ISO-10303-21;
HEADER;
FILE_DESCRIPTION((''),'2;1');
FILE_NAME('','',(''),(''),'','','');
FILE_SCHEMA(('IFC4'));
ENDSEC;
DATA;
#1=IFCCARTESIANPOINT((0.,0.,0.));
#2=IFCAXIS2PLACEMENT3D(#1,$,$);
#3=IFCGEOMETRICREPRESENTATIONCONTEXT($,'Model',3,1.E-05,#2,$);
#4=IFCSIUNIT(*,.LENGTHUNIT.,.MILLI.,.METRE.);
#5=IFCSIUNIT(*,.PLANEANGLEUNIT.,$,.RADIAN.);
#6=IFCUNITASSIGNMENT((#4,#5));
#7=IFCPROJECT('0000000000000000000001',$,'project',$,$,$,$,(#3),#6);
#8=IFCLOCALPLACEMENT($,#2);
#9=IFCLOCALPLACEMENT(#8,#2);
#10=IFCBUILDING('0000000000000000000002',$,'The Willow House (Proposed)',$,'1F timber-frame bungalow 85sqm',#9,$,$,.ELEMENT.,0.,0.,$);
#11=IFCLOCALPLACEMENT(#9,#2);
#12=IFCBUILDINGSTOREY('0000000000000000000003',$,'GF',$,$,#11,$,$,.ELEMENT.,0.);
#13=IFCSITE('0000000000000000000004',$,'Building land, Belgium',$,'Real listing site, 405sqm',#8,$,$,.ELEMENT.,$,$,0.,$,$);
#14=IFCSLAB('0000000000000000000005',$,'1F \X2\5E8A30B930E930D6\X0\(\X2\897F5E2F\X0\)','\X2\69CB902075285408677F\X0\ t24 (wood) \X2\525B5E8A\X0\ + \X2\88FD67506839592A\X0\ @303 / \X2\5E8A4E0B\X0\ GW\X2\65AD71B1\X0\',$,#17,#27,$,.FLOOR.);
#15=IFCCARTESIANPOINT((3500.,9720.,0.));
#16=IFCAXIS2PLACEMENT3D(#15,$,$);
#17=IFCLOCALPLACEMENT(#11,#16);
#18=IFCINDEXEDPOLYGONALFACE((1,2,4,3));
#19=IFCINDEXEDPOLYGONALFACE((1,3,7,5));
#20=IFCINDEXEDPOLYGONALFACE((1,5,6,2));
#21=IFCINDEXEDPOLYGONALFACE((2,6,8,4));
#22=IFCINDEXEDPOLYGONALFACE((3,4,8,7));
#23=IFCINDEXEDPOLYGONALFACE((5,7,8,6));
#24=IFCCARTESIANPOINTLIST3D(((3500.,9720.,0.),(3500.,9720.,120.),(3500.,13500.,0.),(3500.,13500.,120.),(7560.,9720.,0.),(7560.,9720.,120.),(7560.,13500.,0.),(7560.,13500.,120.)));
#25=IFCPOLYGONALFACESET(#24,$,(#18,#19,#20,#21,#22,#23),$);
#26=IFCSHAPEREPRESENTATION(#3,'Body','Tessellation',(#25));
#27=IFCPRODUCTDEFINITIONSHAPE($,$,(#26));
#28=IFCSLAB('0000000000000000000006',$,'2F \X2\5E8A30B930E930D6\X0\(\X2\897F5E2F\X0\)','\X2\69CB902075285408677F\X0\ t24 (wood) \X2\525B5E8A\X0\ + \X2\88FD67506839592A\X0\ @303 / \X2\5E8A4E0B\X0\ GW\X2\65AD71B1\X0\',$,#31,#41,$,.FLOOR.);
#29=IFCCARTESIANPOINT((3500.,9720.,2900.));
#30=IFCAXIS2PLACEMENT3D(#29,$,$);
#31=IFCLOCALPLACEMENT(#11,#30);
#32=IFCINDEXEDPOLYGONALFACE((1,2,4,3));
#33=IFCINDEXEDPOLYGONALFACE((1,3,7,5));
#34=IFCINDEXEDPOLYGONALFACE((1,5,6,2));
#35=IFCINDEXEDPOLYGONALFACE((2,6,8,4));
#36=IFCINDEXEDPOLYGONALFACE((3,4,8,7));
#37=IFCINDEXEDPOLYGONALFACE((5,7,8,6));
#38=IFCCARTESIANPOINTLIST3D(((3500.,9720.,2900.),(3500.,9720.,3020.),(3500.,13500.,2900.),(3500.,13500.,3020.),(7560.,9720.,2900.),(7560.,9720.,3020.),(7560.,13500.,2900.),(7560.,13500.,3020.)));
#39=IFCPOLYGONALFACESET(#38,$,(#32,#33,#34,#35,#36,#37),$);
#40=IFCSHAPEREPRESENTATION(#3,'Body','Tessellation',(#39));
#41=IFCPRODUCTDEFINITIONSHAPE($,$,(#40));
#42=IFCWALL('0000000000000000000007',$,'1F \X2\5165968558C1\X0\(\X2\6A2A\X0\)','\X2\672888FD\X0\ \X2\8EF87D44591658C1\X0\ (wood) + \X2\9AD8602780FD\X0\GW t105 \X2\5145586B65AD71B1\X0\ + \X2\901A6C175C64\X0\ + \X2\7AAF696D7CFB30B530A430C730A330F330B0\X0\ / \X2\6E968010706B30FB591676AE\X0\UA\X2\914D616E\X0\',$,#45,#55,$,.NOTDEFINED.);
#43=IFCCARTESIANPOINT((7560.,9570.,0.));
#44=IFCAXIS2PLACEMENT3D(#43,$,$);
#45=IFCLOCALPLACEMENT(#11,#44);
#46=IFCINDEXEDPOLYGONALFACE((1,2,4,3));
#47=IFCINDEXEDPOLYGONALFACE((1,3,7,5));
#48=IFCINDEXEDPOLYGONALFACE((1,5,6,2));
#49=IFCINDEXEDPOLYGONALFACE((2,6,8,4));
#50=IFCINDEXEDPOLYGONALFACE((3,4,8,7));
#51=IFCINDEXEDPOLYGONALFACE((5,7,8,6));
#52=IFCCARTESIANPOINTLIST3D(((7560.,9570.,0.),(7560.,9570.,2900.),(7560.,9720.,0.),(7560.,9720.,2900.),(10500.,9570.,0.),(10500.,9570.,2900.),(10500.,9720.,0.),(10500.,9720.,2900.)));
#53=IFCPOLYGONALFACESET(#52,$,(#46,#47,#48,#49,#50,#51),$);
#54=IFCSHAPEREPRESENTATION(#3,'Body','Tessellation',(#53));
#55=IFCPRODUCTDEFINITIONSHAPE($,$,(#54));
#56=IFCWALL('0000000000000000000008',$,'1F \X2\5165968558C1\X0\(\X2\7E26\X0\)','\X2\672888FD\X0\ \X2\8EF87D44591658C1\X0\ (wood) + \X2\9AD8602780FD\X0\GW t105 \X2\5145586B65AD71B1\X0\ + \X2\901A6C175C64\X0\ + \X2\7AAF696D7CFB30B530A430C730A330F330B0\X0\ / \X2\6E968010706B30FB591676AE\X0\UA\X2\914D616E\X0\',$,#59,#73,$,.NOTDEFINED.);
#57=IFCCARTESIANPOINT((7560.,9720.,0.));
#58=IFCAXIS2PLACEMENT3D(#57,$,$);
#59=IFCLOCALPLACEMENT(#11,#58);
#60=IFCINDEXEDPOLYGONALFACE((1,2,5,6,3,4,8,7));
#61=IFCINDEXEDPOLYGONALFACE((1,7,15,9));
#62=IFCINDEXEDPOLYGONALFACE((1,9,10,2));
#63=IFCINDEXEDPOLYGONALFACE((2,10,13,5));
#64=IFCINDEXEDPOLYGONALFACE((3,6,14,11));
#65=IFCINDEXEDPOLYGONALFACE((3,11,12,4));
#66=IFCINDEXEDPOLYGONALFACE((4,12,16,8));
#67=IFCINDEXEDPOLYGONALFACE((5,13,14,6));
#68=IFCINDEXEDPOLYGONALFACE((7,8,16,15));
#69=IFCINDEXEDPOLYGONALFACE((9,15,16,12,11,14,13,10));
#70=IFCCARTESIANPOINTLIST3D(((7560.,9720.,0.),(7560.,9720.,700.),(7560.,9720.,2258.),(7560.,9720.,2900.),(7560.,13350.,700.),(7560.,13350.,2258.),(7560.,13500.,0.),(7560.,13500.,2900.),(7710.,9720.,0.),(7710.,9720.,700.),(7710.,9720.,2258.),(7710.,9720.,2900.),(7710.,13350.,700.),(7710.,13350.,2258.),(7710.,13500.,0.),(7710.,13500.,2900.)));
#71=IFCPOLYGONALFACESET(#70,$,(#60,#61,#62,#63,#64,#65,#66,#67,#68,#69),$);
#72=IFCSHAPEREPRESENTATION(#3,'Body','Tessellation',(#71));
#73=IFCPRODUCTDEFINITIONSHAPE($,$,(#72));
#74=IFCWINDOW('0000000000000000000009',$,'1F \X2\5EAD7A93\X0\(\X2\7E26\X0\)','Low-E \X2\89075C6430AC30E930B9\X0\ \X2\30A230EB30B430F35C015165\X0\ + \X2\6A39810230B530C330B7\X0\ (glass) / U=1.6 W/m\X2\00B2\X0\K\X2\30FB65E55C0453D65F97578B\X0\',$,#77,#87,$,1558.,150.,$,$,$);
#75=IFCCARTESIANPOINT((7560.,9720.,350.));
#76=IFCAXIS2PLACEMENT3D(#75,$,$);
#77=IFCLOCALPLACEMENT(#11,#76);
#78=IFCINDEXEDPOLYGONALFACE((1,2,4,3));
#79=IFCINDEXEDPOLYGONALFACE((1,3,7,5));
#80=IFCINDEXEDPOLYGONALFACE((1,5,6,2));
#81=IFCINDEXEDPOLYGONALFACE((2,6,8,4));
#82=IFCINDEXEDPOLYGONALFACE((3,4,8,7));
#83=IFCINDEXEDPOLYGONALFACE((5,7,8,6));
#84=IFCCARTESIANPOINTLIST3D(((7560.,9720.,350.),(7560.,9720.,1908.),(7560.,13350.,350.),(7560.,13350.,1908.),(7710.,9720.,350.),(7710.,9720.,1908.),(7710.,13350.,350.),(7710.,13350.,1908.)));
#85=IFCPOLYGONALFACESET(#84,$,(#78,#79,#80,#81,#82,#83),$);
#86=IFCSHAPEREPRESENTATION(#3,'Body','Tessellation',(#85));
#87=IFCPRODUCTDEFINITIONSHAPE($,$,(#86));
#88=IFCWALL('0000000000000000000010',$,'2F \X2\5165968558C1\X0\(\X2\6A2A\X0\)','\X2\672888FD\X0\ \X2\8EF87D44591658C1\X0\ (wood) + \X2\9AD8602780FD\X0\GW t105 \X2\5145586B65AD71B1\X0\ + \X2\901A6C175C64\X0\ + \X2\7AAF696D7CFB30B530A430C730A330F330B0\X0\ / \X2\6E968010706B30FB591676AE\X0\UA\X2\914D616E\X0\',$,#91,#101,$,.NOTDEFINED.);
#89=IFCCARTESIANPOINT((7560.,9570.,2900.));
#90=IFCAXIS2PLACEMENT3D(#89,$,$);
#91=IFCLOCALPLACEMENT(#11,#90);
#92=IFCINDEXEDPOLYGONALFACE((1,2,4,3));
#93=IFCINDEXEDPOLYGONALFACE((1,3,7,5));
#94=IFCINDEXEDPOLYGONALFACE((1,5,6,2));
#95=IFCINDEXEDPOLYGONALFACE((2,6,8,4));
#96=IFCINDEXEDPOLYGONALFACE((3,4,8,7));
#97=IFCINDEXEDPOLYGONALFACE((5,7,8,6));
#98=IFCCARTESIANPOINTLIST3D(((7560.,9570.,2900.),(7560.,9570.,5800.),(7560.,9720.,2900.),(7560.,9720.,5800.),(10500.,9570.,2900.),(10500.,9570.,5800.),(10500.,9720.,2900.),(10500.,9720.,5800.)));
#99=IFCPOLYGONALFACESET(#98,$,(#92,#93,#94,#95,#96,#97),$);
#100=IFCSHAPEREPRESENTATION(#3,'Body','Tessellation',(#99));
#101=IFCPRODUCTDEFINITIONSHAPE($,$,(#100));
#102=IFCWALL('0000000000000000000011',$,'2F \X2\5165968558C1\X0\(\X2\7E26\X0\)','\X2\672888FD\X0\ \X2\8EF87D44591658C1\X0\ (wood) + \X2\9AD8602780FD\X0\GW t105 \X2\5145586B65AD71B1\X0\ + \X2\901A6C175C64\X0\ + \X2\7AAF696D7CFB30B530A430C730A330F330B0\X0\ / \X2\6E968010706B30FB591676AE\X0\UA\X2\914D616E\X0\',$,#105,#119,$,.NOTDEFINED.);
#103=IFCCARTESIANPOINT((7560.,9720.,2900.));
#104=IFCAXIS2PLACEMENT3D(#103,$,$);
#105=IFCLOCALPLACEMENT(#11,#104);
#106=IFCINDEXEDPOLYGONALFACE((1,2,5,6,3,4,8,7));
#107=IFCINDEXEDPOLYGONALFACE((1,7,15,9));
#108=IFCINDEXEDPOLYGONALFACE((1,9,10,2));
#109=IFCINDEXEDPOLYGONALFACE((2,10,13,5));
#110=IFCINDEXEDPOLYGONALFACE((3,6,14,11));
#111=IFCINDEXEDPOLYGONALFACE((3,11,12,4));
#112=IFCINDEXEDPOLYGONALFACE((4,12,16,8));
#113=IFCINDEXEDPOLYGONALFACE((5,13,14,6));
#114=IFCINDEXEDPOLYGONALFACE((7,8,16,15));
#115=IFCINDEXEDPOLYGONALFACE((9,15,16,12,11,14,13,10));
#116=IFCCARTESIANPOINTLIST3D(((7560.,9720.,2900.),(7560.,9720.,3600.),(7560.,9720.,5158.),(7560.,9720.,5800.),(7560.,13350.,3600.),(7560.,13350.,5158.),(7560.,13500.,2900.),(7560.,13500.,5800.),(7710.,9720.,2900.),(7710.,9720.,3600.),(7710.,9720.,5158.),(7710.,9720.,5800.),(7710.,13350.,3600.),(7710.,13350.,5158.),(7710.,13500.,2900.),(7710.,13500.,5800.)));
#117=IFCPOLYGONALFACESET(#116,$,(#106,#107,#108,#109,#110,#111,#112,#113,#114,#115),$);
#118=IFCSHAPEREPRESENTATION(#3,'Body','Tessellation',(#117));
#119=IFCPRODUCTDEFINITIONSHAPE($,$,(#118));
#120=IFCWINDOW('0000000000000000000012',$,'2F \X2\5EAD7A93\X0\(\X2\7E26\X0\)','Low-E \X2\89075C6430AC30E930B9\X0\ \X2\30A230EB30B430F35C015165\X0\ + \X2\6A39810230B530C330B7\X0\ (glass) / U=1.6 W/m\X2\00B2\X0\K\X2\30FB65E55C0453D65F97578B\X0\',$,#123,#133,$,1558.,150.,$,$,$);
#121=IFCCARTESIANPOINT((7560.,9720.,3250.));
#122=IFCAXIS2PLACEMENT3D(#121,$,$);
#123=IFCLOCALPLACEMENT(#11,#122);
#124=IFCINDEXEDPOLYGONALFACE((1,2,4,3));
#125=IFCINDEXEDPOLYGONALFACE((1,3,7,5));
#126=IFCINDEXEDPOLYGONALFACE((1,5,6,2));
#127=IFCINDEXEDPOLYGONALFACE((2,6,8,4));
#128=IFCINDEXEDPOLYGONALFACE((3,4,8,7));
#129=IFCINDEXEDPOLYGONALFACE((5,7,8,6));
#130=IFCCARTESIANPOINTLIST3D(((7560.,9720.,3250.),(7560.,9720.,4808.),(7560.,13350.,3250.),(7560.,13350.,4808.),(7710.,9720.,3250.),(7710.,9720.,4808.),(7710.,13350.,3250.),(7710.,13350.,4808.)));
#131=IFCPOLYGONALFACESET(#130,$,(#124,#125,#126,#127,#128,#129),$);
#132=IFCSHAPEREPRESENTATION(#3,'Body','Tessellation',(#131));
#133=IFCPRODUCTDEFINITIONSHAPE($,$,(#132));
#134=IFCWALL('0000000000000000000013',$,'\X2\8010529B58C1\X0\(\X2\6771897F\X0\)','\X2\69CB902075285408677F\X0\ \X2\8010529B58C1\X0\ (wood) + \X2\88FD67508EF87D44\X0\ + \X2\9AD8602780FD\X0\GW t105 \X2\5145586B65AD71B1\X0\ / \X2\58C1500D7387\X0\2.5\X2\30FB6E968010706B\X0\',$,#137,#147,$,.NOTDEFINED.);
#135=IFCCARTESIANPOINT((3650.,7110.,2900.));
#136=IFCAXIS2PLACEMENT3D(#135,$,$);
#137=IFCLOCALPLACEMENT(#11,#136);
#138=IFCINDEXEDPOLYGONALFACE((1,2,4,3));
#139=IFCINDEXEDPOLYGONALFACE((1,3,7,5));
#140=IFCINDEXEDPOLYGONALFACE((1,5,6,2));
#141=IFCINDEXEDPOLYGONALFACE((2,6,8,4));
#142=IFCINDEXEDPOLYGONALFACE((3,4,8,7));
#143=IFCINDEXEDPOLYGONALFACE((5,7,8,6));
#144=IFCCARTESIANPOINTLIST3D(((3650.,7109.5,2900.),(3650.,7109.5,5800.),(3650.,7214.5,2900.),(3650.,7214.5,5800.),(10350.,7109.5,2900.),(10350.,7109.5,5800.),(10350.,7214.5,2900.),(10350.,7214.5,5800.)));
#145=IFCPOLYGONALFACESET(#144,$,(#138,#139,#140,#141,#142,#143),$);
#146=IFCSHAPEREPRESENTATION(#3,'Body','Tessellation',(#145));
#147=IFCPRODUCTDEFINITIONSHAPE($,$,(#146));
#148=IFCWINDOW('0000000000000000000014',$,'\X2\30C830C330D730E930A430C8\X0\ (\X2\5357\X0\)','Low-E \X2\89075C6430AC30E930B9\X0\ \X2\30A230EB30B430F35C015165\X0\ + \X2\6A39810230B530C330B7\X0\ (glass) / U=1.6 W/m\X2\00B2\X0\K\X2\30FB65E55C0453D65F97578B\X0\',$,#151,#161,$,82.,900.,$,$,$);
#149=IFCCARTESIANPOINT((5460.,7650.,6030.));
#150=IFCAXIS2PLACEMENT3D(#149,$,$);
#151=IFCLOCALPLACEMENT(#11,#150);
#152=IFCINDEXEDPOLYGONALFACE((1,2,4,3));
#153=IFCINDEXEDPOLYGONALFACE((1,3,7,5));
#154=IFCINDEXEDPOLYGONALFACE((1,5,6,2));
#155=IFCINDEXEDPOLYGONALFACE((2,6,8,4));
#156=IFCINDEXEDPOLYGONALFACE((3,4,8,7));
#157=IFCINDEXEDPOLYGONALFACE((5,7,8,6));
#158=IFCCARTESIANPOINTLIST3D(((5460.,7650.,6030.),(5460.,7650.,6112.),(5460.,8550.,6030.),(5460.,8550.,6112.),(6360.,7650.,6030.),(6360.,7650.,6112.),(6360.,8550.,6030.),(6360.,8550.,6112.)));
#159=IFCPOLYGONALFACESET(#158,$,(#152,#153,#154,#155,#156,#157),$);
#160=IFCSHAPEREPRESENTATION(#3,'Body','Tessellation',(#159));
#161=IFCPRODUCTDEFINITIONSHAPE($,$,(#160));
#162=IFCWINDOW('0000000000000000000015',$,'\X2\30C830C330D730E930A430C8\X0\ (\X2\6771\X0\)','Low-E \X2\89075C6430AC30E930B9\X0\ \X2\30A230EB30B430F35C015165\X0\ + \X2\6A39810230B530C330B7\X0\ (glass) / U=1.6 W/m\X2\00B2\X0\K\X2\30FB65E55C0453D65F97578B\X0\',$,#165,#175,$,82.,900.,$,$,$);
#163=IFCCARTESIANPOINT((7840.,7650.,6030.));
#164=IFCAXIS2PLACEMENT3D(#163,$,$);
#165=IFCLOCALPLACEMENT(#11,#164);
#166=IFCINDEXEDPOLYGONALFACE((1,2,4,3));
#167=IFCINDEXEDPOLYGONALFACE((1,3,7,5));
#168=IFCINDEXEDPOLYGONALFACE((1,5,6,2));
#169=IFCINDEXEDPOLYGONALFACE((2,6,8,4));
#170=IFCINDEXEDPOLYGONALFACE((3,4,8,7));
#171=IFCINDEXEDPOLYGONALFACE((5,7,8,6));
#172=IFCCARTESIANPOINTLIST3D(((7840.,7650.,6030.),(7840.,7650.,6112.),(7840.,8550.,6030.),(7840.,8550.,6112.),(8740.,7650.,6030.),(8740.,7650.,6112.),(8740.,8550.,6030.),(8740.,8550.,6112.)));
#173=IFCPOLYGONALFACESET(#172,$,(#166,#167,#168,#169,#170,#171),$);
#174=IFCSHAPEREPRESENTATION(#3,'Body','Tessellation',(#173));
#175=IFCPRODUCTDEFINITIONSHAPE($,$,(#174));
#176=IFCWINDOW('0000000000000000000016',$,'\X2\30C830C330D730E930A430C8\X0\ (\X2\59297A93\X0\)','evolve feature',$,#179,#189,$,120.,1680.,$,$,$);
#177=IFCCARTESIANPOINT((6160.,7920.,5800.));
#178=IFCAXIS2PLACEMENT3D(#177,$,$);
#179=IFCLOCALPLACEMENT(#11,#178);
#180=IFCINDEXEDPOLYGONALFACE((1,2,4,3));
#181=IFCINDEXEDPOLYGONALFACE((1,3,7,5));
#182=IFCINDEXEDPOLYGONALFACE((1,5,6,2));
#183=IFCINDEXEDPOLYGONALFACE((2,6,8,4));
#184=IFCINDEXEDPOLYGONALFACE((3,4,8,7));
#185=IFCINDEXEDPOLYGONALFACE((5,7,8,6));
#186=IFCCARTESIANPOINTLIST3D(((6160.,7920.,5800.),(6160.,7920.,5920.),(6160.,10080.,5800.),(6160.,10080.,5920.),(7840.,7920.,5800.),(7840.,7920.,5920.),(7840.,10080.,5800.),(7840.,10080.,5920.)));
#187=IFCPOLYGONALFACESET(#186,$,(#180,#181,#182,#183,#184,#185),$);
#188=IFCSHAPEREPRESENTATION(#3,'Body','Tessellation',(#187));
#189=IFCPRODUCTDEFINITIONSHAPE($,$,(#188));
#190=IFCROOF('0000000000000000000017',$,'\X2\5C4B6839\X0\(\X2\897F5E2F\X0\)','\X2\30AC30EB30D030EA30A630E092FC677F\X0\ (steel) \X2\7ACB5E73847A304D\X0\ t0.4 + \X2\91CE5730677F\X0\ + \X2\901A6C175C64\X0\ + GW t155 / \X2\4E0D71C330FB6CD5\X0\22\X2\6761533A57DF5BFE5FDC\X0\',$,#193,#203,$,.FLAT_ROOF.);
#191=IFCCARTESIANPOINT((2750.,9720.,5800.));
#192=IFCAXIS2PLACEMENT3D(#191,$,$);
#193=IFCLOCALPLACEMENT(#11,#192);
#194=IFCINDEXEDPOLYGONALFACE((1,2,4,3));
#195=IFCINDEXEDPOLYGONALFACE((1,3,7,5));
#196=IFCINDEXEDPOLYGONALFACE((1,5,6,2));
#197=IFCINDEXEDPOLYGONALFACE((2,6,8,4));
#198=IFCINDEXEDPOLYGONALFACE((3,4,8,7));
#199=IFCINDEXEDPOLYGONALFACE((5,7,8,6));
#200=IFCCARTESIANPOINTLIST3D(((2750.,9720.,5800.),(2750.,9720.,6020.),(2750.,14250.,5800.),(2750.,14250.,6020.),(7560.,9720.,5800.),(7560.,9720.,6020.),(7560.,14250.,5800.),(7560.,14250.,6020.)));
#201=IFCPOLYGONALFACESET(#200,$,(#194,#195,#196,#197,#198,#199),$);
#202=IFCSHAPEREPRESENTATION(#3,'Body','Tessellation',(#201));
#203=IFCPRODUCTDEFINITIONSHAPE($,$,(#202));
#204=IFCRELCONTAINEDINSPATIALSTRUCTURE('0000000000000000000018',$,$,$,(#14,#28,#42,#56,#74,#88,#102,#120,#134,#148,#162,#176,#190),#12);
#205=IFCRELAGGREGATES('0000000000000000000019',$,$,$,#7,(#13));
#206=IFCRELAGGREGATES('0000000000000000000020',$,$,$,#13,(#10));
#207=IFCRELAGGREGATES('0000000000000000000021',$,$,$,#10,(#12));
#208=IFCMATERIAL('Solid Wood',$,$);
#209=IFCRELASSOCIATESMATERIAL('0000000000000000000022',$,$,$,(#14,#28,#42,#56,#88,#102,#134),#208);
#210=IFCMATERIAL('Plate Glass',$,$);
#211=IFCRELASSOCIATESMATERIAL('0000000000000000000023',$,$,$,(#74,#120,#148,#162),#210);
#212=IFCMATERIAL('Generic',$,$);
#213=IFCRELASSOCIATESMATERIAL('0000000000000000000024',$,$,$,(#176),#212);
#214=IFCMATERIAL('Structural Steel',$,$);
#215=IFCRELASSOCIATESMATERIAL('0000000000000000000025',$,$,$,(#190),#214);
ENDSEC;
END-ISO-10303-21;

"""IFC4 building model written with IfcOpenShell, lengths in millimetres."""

from ifc_helpers import new_model, si_unit, frame, frame_2d, origin, place, context, project, spatial, rectangle, extrude, material, element, fill, save


model = new_model("IFC4")

# Units and contexts
model_context = context("Model", 3, precision=1e-05, world=origin())
ifc_project = project(units=[si_unit("LENGTHUNIT", "METRE", prefix="MILLI"), si_unit("PLANEANGLEUNIT", "RADIAN")], contexts=[model_context])

# Site, building, storey
site_placement = place(None, origin())
site = spatial("IfcSite", under=ifc_project, at=site_placement, Name="Building land, Belgium", ObjectType="Real listing site, 405sqm", CompositionType="ELEMENT", RefElevation=0.0)
building_placement = place(site_placement, origin())
building = spatial("IfcBuilding", under=site, at=building_placement, Name="The Willow House (Proposed)", ObjectType="1F timber-frame bungalow 85sqm", CompositionType="ELEMENT", ElevationOfRefHeight=0.0, ElevationOfTerrain=0.0)
storey_placement = place(building_placement, origin())
storey = spatial("IfcBuildingStorey", under=building, at=storey_placement, Name="GF", CompositionType="ELEMENT", Elevation=0.0)

# Slabs
ifc_material_1 = material(Name="Solid Wood")
slab_1_placement = place(storey_placement, frame((3500.0, 9720.0, 0.0)))
element("IfcSlab", 1, at=slab_1_placement, inside=storey, material=ifc_material_1, Name="1F 床スラブ(西帯)", Description="構造用合板 t24 (wood) 剛床 + 製材根太 @303 / 床下 GW断熱", PredefinedType="FLOOR", context=model_context, shape_type="SweptSolid", body=[
    extrude(rectangle(XDim=4060.0, YDim=3780.0, at=frame_2d((2030.0, 1890.0))), frame((3500.0, 9720.0, 0.0)), (0.0, 0.0, 1.0), 120.0),
])
slab_2_placement = place(storey_placement, frame((3500.0, 9720.0, 2900.0)))
element("IfcSlab", 2, at=slab_2_placement, inside=storey, material=ifc_material_1, Name="2F 床スラブ(西帯)", Description="構造用合板 t24 (wood) 剛床 + 製材根太 @303 / 床下 GW断熱", PredefinedType="FLOOR", context=model_context, shape_type="SweptSolid", body=[
    extrude(rectangle(XDim=4060.0, YDim=3780.0, at=frame_2d((2030.0, 1890.0))), frame((3500.0, 9720.0, 2900.0)), (0.0, 0.0, 1.0), 120.0),
])

# Wall
wall_1_placement = place(storey_placement, frame((7560.0, 9570.0, 0.0)))
element("IfcWall", 3, at=wall_1_placement, inside=storey, material=ifc_material_1, Name="1F 入隅壁(横)", Description="木製 軸組外壁 (wood) + 高性能GW t105 充填断熱 + 通気層 + 窯業系サイディング / 準耐火・外皮UA配慮", PredefinedType="NOTDEFINED", context=model_context, shape_type="SweptSolid", body=[
    extrude(rectangle(XDim=2940.0, YDim=150.0, at=frame_2d((1470.0, 75.0))), frame((7560.0, 9570.0, 0.0)), (0.0, 0.0, 1.0), 2900.0),
])

# Wall, opening, window
wall_2_placement = place(storey_placement, frame((7560.0, 9720.0, 0.0)))
wall_2 = element("IfcWall", 4, at=wall_2_placement, inside=storey, material=ifc_material_1, Name="1F 入隅壁(縦)", Description="木製 軸組外壁 (wood) + 高性能GW t105 充填断熱 + 通気層 + 窯業系サイディング / 準耐火・外皮UA配慮", PredefinedType="NOTDEFINED", context=model_context, shape_type="SweptSolid", body=[
    extrude(rectangle(XDim=150.0, YDim=3780.0, at=frame_2d((75.0, 1890.0))), frame((7560.0, 9720.0, 0.0)), (0.0, 0.0, 1.0), 2900.0),
])
opening_1_placement = place(storey_placement, frame((7560.0, 9720.0, 350.0)))
opening_1 = element("IfcOpeningElement", 5, at=opening_1_placement, cuts=wall_2, PredefinedType="NOTDEFINED", context=model_context, shape_type="SweptSolid", body=[
    extrude(rectangle(XDim=150.0, YDim=3630.0, at=frame_2d((75.0, 1815.0))), frame((7560.0, 9720.0, 350.0)), (0.0, 0.0, 1.0), 1558.0),
])
ifc_material_2 = material(Name="Plate Glass")
window_1_placement = place(storey_placement, frame((7560.0, 9720.0, 350.0)))
window_1 = element("IfcWindow", 6, at=window_1_placement, inside=storey, material=ifc_material_2, Name="1F 庭窓(縦)", Description="Low-E 複層ガラス アルゴン封入 + 樹脂サッシ (glass) / U=1.6 W/m²K・日射取得型", OverallHeight=1558.0, OverallWidth=150.0, context=model_context, shape_type="SweptSolid", body=[
    extrude(rectangle(XDim=150.0, YDim=3630.0, at=frame_2d((75.0, 1815.0))), frame((7560.0, 9720.0, 350.0)), (0.0, 0.0, 1.0), 1558.0),
])
fill(opening_1, window_1)

# Wall
wall_3_placement = place(storey_placement, frame((7560.0, 9570.0, 2900.0)))
element("IfcWall", 7, at=wall_3_placement, inside=storey, material=ifc_material_1, Name="2F 入隅壁(横)", Description="木製 軸組外壁 (wood) + 高性能GW t105 充填断熱 + 通気層 + 窯業系サイディング / 準耐火・外皮UA配慮", PredefinedType="NOTDEFINED", context=model_context, shape_type="SweptSolid", body=[
    extrude(rectangle(XDim=2940.0, YDim=150.0, at=frame_2d((1470.0, 75.0))), frame((7560.0, 9570.0, 2900.0)), (0.0, 0.0, 1.0), 2900.0),
])

# Wall, opening, window
wall_4_placement = place(storey_placement, frame((7560.0, 9720.0, 2900.0)))
wall_4 = element("IfcWall", 8, at=wall_4_placement, inside=storey, material=ifc_material_1, Name="2F 入隅壁(縦)", Description="木製 軸組外壁 (wood) + 高性能GW t105 充填断熱 + 通気層 + 窯業系サイディング / 準耐火・外皮UA配慮", PredefinedType="NOTDEFINED", context=model_context, shape_type="SweptSolid", body=[
    extrude(rectangle(XDim=150.0, YDim=3780.0, at=frame_2d((75.0, 1890.0))), frame((7560.0, 9720.0, 2900.0)), (0.0, 0.0, 1.0), 2900.0),
])
opening_2_placement = place(storey_placement, frame((7560.0, 9720.0, 3250.0)))
opening_2 = element("IfcOpeningElement", 9, at=opening_2_placement, cuts=wall_4, PredefinedType="NOTDEFINED", context=model_context, shape_type="SweptSolid", body=[
    extrude(rectangle(XDim=150.0, YDim=3630.0, at=frame_2d((75.0, 1815.0))), frame((7560.0, 9720.0, 3250.0)), (0.0, 0.0, 1.0), 1558.0),
])
window_2_placement = place(storey_placement, frame((7560.0, 9720.0, 3250.0)))
window_2 = element("IfcWindow", 10, at=window_2_placement, inside=storey, material=ifc_material_2, Name="2F 庭窓(縦)", Description="Low-E 複層ガラス アルゴン封入 + 樹脂サッシ (glass) / U=1.6 W/m²K・日射取得型", OverallHeight=1558.0, OverallWidth=150.0, context=model_context, shape_type="SweptSolid", body=[
    extrude(rectangle(XDim=150.0, YDim=3630.0, at=frame_2d((75.0, 1815.0))), frame((7560.0, 9720.0, 3250.0)), (0.0, 0.0, 1.0), 1558.0),
])
fill(opening_2, window_2)

# Wall
wall_5_placement = place(storey_placement, frame((3650.0, 7110.0, 2900.0)))
element("IfcWall", 11, at=wall_5_placement, inside=storey, material=ifc_material_1, Name="耐力壁(東西)", Description="構造用合板 耐力壁 (wood) + 製材軸組 + 高性能GW t105 充填断熱 / 壁倍率2.5・準耐火", PredefinedType="NOTDEFINED", context=model_context, shape_type="SweptSolid", body=[
    extrude(rectangle(XDim=6700.0, YDim=105.0, at=frame_2d((3350.0, 52.0))), frame((3650.0, 7110.0, 2900.0)), (0.0, 0.0, 1.0), 2900.0),
])

# Windows
window_3_placement = place(storey_placement, frame((5460.0, 7650.0, 6030.0)))
element("IfcWindow", 12, at=window_3_placement, inside=storey, material=ifc_material_2, Name="トップライト (南)", Description="Low-E 複層ガラス アルゴン封入 + 樹脂サッシ (glass) / U=1.6 W/m²K・日射取得型", OverallHeight=82.0, OverallWidth=900.0, context=model_context, shape_type="SweptSolid", body=[
    extrude(rectangle(XDim=900.0, YDim=900.0, at=frame_2d((450.0, 450.0))), frame((5460.0, 7650.0, 6030.0)), (0.0, 0.0, 1.0), 82.0),
])
window_4_placement = place(storey_placement, frame((7840.0, 7650.0, 6030.0)))
element("IfcWindow", 13, at=window_4_placement, inside=storey, material=ifc_material_2, Name="トップライト (東)", Description="Low-E 複層ガラス アルゴン封入 + 樹脂サッシ (glass) / U=1.6 W/m²K・日射取得型", OverallHeight=82.0, OverallWidth=900.0, context=model_context, shape_type="SweptSolid", body=[
    extrude(rectangle(XDim=900.0, YDim=900.0, at=frame_2d((450.0, 450.0))), frame((7840.0, 7650.0, 6030.0)), (0.0, 0.0, 1.0), 82.0),
])
ifc_material_3 = material(Name="Generic")
window_5_placement = place(storey_placement, frame((6160.0, 7920.0, 5800.0)))
element("IfcWindow", 14, at=window_5_placement, inside=storey, material=ifc_material_3, Name="トップライト (天窓)", Description="evolve feature", OverallHeight=120.0, OverallWidth=1680.0, context=model_context, shape_type="SweptSolid", body=[
    extrude(rectangle(XDim=1680.0, YDim=2160.0, at=frame_2d((840.0, 1080.0))), frame((6160.0, 7920.0, 5800.0)), (0.0, 0.0, 1.0), 120.0),
])

# Roof
ifc_material_4 = material(Name="Structural Steel")
for number, where, name in (
    (15, (2750.0, 9720.0, 5800.0), "屋根(西帯)"),
):
    element("IfcRoof", number, at=place(storey_placement, frame(where)), inside=storey, material=ifc_material_4, Name=name, Description="ガルバリウム鋼板 (steel) 立平葺き t0.4 + 野地板 + 通気層 + GW t155 / 不燃・法22条区域対応", PredefinedType="FLAT_ROOF", context=model_context, shape_type="SweptSolid", body=[
        extrude(rectangle(XDim=4810.0, YDim=4530.0, at=frame_2d((2405.0, 2265.0))), frame((2750.0, 9720.0, 5800.0)), (0.0, 0.0, 1.0), 220.0),
    ])

save(model, "model.ifc")
